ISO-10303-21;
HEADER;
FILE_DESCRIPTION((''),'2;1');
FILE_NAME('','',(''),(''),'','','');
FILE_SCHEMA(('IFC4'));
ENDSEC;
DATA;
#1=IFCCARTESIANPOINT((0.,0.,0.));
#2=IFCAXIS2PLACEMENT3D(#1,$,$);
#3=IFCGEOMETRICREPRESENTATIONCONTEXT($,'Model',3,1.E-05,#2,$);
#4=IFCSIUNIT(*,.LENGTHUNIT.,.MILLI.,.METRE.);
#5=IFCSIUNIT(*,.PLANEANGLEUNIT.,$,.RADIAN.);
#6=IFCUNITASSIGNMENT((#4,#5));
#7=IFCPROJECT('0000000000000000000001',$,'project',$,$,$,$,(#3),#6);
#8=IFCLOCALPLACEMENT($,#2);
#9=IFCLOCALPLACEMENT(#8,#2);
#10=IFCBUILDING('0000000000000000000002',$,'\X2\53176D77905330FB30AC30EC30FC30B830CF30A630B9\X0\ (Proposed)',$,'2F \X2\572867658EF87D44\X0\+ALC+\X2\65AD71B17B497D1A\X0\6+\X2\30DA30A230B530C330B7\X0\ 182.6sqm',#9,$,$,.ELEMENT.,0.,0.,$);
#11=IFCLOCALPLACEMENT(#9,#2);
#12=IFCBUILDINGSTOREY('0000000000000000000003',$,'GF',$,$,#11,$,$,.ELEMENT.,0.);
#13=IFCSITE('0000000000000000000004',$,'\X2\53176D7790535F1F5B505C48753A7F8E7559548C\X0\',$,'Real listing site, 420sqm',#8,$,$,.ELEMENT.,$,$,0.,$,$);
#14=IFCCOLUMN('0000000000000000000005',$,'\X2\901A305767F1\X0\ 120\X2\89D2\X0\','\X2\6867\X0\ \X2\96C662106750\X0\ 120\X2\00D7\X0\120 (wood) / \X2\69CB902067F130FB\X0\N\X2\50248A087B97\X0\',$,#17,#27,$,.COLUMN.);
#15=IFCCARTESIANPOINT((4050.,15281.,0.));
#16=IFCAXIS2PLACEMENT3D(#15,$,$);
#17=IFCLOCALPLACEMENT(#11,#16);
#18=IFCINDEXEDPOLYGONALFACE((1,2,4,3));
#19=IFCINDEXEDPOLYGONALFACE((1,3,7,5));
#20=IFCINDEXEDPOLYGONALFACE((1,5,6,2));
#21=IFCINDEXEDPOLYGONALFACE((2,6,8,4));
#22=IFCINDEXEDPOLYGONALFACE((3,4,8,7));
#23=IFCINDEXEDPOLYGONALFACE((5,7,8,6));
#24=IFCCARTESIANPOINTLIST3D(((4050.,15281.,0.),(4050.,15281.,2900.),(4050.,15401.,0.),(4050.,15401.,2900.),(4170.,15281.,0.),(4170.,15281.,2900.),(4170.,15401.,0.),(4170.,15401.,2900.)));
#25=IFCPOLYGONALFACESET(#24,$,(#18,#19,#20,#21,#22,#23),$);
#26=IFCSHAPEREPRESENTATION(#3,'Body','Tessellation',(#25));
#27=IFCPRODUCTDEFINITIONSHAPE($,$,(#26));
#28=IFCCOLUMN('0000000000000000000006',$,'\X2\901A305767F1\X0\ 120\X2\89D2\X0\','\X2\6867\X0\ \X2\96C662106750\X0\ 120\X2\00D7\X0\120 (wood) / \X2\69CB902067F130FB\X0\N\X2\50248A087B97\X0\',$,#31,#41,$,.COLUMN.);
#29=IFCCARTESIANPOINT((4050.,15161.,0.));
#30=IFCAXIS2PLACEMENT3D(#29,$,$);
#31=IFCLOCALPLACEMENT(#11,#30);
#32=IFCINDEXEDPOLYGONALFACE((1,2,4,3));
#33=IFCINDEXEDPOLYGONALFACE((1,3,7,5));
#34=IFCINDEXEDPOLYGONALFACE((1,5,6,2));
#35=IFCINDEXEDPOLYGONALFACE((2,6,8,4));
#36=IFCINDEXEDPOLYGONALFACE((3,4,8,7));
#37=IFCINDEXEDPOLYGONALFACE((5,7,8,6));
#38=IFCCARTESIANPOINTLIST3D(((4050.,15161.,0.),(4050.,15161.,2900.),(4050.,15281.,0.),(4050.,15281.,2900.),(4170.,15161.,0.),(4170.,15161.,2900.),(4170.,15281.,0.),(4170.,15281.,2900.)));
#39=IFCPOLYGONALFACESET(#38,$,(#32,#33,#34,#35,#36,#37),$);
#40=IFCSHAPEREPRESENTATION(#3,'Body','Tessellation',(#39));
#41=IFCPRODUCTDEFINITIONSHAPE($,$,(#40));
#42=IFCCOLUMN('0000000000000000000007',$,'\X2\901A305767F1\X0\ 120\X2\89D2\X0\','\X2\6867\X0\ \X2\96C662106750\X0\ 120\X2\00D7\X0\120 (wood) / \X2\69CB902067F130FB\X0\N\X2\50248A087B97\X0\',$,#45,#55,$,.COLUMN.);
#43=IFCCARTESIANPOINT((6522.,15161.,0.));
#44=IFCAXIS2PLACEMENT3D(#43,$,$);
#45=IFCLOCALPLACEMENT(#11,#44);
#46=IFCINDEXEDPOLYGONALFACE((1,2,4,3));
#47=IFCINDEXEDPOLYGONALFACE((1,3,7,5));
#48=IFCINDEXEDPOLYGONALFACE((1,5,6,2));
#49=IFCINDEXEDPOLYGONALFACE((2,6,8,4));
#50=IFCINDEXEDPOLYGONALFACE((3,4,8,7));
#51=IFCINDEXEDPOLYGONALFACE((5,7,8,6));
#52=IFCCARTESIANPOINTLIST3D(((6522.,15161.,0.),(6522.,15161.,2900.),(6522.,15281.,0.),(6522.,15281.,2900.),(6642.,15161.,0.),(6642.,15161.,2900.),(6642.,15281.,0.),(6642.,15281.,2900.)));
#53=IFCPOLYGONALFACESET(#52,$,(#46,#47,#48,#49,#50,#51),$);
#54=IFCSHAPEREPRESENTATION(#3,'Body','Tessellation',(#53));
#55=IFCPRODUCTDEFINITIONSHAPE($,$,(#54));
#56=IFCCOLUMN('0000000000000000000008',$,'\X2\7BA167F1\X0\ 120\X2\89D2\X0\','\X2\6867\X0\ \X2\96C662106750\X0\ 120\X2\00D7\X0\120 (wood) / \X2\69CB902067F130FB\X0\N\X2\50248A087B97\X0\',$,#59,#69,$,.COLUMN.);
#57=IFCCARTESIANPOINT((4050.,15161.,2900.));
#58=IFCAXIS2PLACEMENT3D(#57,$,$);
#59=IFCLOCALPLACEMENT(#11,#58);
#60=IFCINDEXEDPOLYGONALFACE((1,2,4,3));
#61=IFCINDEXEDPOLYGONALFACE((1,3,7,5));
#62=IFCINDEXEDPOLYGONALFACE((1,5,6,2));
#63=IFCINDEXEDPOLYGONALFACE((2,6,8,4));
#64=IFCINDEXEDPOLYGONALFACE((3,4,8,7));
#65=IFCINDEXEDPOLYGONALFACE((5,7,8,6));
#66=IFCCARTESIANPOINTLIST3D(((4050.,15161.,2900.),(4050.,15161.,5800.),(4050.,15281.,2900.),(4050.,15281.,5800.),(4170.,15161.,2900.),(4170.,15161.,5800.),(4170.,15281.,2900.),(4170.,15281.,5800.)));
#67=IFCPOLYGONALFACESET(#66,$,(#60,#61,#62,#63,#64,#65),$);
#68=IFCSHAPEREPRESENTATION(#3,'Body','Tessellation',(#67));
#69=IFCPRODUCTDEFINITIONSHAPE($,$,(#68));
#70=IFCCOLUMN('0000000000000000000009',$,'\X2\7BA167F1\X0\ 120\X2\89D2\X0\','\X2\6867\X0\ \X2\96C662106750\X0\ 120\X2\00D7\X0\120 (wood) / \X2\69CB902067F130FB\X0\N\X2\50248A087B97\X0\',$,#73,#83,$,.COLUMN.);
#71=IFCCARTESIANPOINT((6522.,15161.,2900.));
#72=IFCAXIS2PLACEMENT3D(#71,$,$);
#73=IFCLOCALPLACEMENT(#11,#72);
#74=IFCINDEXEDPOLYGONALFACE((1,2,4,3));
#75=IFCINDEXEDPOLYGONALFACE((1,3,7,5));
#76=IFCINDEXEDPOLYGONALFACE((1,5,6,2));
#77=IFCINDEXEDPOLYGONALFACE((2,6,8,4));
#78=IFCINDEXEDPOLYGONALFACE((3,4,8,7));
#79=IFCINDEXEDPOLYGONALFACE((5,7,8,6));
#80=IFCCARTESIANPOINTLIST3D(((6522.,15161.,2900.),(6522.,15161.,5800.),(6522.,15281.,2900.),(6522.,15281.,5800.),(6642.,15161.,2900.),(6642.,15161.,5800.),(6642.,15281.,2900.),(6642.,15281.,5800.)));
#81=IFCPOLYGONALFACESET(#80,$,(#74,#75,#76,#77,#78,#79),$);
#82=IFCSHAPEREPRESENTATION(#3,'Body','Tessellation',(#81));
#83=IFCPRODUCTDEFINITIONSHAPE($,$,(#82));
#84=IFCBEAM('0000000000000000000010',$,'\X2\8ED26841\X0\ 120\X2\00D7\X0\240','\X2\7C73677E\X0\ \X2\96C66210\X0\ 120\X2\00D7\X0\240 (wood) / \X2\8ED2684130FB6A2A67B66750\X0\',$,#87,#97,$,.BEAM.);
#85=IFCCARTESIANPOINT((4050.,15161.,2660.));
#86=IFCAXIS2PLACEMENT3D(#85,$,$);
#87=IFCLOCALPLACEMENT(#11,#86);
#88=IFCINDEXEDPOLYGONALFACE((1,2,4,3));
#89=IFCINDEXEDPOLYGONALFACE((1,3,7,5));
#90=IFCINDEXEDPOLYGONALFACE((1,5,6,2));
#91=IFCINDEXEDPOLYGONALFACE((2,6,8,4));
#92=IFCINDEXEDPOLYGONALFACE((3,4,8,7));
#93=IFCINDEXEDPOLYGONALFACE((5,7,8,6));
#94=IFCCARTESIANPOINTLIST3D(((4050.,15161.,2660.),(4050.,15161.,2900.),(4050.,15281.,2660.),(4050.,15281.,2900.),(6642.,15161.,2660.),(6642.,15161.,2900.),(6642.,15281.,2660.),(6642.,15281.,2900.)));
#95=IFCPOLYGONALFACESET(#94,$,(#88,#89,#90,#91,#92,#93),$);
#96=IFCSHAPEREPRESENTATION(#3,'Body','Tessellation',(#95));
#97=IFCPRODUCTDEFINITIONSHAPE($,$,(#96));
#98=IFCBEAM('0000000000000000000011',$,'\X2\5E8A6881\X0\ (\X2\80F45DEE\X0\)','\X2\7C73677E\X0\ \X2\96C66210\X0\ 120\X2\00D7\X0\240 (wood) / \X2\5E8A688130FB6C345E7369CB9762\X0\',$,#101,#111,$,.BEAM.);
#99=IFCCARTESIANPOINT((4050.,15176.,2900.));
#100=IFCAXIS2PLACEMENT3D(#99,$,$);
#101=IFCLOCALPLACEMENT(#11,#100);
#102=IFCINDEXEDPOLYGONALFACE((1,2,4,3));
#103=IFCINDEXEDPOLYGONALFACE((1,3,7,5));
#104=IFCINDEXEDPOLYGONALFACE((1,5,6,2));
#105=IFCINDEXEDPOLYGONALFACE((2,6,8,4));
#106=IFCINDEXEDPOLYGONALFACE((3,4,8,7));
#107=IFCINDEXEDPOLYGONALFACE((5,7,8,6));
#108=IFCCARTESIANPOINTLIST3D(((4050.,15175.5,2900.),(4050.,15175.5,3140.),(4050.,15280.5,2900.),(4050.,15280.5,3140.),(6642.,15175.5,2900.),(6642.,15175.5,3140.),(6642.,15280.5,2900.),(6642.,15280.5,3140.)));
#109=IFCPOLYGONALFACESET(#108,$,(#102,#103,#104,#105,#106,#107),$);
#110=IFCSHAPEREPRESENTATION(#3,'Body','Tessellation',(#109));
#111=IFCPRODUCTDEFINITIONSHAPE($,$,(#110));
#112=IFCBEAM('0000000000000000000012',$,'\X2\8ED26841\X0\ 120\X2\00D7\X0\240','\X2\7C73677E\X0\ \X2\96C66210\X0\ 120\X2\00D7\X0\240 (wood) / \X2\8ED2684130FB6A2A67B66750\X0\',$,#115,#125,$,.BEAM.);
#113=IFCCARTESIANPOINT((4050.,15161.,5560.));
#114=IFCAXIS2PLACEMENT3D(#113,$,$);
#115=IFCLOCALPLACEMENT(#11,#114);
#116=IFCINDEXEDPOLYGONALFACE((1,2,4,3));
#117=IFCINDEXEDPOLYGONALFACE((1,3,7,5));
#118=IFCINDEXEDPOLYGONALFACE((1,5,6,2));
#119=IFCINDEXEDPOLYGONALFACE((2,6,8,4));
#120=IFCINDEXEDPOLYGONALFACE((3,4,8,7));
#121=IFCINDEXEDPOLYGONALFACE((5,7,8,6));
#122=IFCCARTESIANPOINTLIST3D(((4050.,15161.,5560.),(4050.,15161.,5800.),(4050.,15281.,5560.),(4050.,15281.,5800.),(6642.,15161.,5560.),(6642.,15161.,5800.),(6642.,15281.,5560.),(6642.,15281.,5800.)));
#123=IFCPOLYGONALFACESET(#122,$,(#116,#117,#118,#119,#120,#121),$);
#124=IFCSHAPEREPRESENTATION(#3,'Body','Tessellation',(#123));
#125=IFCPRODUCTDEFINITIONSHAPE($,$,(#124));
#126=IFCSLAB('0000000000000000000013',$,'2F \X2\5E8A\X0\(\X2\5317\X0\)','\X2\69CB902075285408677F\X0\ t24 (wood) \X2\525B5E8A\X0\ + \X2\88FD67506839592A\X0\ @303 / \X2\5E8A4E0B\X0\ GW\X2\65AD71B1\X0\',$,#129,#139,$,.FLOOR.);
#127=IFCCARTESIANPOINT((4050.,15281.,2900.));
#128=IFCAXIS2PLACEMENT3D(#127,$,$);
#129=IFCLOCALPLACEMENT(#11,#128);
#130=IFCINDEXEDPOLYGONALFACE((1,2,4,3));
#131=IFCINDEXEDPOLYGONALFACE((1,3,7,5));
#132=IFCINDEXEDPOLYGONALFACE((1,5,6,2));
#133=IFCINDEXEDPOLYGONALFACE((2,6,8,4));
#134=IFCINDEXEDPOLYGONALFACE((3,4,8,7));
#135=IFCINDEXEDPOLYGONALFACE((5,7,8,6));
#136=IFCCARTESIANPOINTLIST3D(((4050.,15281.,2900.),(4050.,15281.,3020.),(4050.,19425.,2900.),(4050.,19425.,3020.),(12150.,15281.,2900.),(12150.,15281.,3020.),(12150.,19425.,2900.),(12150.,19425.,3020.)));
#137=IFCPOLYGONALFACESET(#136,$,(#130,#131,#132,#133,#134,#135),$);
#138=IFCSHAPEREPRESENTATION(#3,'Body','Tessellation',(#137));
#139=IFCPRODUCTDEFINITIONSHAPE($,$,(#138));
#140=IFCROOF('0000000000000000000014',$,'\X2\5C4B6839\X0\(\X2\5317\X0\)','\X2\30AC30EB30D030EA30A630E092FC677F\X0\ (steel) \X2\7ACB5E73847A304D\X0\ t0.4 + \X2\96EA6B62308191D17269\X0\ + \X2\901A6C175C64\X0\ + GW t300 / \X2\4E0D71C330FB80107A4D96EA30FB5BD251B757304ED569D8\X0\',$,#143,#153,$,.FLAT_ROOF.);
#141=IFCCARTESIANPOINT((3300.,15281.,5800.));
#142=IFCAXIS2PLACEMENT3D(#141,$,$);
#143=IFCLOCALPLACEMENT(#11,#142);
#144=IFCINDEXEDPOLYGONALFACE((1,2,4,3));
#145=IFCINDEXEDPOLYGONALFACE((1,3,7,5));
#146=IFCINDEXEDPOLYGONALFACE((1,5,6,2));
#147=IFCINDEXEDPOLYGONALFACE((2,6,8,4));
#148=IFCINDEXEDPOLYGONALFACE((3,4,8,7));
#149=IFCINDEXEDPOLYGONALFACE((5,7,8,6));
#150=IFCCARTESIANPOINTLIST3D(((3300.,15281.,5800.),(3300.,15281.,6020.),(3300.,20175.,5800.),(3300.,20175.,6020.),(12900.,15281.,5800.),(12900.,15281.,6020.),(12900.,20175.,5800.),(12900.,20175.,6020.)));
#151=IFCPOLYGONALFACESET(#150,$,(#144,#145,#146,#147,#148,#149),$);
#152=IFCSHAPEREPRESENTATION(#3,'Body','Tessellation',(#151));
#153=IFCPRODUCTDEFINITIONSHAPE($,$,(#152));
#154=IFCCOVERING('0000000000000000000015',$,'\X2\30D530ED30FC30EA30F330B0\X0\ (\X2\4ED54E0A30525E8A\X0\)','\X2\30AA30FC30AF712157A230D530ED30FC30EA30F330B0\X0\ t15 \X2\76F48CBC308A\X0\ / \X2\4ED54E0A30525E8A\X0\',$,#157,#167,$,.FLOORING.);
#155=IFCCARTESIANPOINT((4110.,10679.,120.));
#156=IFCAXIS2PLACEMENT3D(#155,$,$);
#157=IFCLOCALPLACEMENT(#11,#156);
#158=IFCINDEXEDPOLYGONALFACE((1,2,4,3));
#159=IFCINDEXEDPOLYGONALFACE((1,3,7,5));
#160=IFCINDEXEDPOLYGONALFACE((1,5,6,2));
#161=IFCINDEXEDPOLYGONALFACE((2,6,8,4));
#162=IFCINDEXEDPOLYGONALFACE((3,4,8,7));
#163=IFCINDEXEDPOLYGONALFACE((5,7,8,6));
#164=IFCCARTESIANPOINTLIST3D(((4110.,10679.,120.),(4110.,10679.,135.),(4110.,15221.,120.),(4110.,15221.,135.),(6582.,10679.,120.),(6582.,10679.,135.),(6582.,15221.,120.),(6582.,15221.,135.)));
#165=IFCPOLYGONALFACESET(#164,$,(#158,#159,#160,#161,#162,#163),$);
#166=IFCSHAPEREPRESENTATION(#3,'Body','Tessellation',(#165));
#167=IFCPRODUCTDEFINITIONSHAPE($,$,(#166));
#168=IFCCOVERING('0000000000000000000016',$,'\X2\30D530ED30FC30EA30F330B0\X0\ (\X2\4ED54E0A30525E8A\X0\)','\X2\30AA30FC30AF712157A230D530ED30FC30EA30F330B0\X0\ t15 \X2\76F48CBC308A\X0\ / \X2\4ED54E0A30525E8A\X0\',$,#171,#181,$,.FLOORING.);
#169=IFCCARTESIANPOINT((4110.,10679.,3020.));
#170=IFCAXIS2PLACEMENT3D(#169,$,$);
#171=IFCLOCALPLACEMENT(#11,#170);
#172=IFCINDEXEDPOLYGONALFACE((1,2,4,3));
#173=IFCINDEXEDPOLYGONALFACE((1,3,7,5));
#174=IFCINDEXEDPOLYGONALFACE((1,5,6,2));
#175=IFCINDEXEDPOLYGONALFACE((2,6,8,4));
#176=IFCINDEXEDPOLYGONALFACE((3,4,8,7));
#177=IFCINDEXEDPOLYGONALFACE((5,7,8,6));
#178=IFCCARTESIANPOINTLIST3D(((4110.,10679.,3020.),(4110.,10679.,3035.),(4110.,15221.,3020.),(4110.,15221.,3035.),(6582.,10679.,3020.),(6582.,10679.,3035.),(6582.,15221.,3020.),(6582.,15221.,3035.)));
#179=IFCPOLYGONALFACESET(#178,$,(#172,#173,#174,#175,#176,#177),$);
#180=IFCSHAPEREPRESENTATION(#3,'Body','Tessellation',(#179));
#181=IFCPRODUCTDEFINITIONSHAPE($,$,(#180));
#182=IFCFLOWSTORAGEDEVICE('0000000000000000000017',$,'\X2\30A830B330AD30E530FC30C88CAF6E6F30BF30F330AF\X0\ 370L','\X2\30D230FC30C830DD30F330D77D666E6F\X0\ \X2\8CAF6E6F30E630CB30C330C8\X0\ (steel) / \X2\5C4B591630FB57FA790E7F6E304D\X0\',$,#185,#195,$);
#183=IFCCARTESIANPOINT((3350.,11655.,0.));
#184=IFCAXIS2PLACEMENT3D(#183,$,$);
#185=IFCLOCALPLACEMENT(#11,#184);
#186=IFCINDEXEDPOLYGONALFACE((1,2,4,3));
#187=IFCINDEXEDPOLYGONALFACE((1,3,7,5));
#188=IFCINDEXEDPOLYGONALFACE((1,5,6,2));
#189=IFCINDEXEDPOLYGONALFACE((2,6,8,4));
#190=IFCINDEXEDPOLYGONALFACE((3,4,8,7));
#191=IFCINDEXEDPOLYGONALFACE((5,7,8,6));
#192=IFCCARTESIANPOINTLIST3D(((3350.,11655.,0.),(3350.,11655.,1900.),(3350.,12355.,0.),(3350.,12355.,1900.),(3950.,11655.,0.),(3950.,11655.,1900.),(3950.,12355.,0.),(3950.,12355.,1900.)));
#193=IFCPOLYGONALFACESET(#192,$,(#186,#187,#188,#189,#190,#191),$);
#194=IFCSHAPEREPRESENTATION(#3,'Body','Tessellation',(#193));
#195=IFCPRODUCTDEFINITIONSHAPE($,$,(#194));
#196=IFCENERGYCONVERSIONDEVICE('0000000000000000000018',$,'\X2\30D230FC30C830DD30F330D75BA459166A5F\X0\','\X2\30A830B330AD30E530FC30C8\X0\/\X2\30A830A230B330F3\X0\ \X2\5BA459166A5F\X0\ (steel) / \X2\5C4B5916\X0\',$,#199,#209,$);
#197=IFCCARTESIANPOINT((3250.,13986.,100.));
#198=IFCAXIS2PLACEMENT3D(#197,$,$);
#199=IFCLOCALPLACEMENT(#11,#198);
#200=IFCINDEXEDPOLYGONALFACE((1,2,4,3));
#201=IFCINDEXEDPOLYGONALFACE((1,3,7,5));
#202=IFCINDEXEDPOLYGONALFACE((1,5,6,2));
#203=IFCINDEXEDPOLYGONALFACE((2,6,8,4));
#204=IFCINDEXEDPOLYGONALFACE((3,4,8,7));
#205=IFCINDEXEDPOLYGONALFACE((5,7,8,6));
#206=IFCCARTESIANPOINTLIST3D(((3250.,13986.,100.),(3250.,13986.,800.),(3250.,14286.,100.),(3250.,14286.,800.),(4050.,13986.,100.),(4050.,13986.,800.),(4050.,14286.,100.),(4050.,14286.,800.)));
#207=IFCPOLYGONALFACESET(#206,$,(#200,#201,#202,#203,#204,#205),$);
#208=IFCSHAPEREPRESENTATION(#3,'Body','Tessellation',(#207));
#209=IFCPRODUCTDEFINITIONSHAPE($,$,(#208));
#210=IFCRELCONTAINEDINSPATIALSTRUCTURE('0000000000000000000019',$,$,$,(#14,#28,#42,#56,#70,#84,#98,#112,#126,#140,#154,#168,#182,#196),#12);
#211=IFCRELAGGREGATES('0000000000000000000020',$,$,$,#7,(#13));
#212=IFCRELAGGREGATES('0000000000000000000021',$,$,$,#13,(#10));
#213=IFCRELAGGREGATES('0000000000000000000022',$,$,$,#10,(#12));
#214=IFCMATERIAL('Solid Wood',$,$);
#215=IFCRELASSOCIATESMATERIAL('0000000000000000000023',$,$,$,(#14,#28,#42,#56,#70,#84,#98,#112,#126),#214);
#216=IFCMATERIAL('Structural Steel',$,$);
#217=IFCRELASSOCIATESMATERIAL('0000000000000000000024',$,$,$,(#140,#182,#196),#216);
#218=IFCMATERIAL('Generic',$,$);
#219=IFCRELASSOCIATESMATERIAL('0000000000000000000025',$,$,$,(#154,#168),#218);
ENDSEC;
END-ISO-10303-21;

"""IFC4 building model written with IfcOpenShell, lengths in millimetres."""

from ifc_helpers import new_model, si_unit, frame, frame_2d, origin, place, context, project, spatial, rectangle, extrude, material, element, save


model = new_model("IFC4")

# Units and contexts
model_context = context("Model", 3, precision=1e-05, world=origin())
ifc_project = project(units=[si_unit("LENGTHUNIT", "METRE", prefix="MILLI"), si_unit("PLANEANGLEUNIT", "RADIAN")], contexts=[model_context])

# Site, building, storey
site_placement = place(None, origin())
site = spatial("IfcSite", under=ifc_project, at=site_placement, Name="北海道弟子屈町美留和", ObjectType="Real listing site, 420sqm", CompositionType="ELEMENT", RefElevation=0.0)
building_placement = place(site_placement, origin())
building = spatial("IfcBuilding", under=site, at=building_placement, Name="北海道・ガレージハウス (Proposed)", ObjectType="2F 在来軸組+ALC+断熱等級6+ペアサッシ 182.6sqm", CompositionType="ELEMENT", ElevationOfRefHeight=0.0, ElevationOfTerrain=0.0)
storey_placement = place(building_placement, origin())
storey = spatial("IfcBuildingStorey", under=building, at=storey_placement, Name="GF", CompositionType="ELEMENT", Elevation=0.0)

# Columns
ifc_material_1 = material(Name="Solid Wood")
column_1_placement = place(storey_placement, frame((4050.0, 15281.0, 0.0)))
element("IfcColumn", 1, at=column_1_placement, inside=storey, material=ifc_material_1, Name="通し柱 120角", Description="桧 集成材 120×120 (wood) / 構造柱・N値計算", PredefinedType="COLUMN", context=model_context, shape_type="SweptSolid", body=[
    extrude(rectangle(XDim=120.0, YDim=120.0, at=frame_2d((60.0, 60.0))), frame((4050.0, 15281.0, 0.0)), (0.0, 0.0, 1.0), 2900.0),
])
column_2_placement = place(storey_placement, frame((4050.0, 15161.0, 0.0)))
element("IfcColumn", 2, at=column_2_placement, inside=storey, material=ifc_material_1, Name="通し柱 120角", Description="桧 集成材 120×120 (wood) / 構造柱・N値計算", PredefinedType="COLUMN", context=model_context, shape_type="SweptSolid", body=[
    extrude(rectangle(XDim=120.0, YDim=120.0, at=frame_2d((60.0, 60.0))), frame((4050.0, 15161.0, 0.0)), (0.0, 0.0, 1.0), 2900.0),
])
column_3_placement = place(storey_placement, frame((6522.0, 15161.0, 0.0)))
element("IfcColumn", 3, at=column_3_placement, inside=storey, material=ifc_material_1, Name="通し柱 120角", Description="桧 集成材 120×120 (wood) / 構造柱・N値計算", PredefinedType="COLUMN", context=model_context, shape_type="SweptSolid", body=[
    extrude(rectangle(XDim=120.0, YDim=120.0, at=frame_2d((60.0, 60.0))), frame((6522.0, 15161.0, 0.0)), (0.0, 0.0, 1.0), 2900.0),
])
column_4_placement = place(storey_placement, frame((4050.0, 15161.0, 2900.0)))
element("IfcColumn", 4, at=column_4_placement, inside=storey, material=ifc_material_1, Name="管柱 120角", Description="桧 集成材 120×120 (wood) / 構造柱・N値計算", PredefinedType="COLUMN", context=model_context, shape_type="SweptSolid", body=[
    extrude(rectangle(XDim=120.0, YDim=120.0, at=frame_2d((60.0, 60.0))), frame((4050.0, 15161.0, 2900.0)), (0.0, 0.0, 1.0), 2900.0),
])
column_5_placement = place(storey_placement, frame((6522.0, 15161.0, 2900.0)))
element("IfcColumn", 5, at=column_5_placement, inside=storey, material=ifc_material_1, Name="管柱 120角", Description="桧 集成材 120×120 (wood) / 構造柱・N値計算", PredefinedType="COLUMN", context=model_context, shape_type="SweptSolid", body=[
    extrude(rectangle(XDim=120.0, YDim=120.0, at=frame_2d((60.0, 60.0))), frame((6522.0, 15161.0, 2900.0)), (0.0, 0.0, 1.0), 2900.0),
])

# Beams
beam_1_placement = place(storey_placement, frame((4050.0, 15161.0, 2660.0)))
element("IfcBeam", 6, at=beam_1_placement, inside=storey, material=ifc_material_1, Name="軒桁 120×240", Description="米松 集成 120×240 (wood) / 軒桁・横架材", PredefinedType="BEAM", context=model_context, shape_type="SweptSolid", body=[
    extrude(rectangle(XDim=2592.0, YDim=120.0, at=frame_2d((1296.0, 60.0))), frame((4050.0, 15161.0, 2660.0)), (0.0, 0.0, 1.0), 240.0),
])
beam_2_placement = place(storey_placement, frame((4050.0, 15176.0, 2900.0)))
element("IfcBeam", 7, at=beam_2_placement, inside=storey, material=ifc_material_1, Name="床梁 (胴差)", Description="米松 集成 120×240 (wood) / 床梁・水平構面", PredefinedType="BEAM", context=model_context, shape_type="SweptSolid", body=[
    extrude(rectangle(XDim=2592.0, YDim=105.0, at=frame_2d((1296.0, 52.0))), frame((4050.0, 15176.0, 2900.0)), (0.0, 0.0, 1.0), 240.0),
])
beam_3_placement = place(storey_placement, frame((4050.0, 15161.0, 5560.0)))
element("IfcBeam", 8, at=beam_3_placement, inside=storey, material=ifc_material_1, Name="軒桁 120×240", Description="米松 集成 120×240 (wood) / 軒桁・横架材", PredefinedType="BEAM", context=model_context, shape_type="SweptSolid", body=[
    extrude(rectangle(XDim=2592.0, YDim=120.0, at=frame_2d((1296.0, 60.0))), frame((4050.0, 15161.0, 5560.0)), (0.0, 0.0, 1.0), 240.0),
])

# Slab
slab_1_placement = place(storey_placement, frame((4050.0, 15281.0, 2900.0)))
element("IfcSlab", 9, at=slab_1_placement, inside=storey, material=ifc_material_1, Name="2F 床(北)", Description="構造用合板 t24 (wood) 剛床 + 製材根太 @303 / 床下 GW断熱", PredefinedType="FLOOR", context=model_context, shape_type="SweptSolid", body=[
    extrude(rectangle(XDim=8100.0, YDim=4144.0, at=frame_2d((4050.0, 2072.0))), frame((4050.0, 15281.0, 2900.0)), (0.0, 0.0, 1.0), 120.0),
])

# Roof
ifc_material_2 = material(Name="Structural Steel")
for number, where, name in (
    (10, (3300.0, 15281.0, 5800.0), "屋根(北)"),
):
    element("IfcRoof", number, at=place(storey_placement, frame(where)), inside=storey, material=ifc_material_2, Name=name, Description="ガルバリウム鋼板 (steel) 立平葺き t0.4 + 雪止め金物 + 通気層 + GW t300 / 不燃・耐積雪・寒冷地仕様", PredefinedType="FLAT_ROOF", context=model_context, shape_type="SweptSolid", body=[
        extrude(rectangle(XDim=9600.0, YDim=4894.0, at=frame_2d((4800.0, 2447.0))), frame((3300.0, 15281.0, 5800.0)), (0.0, 0.0, 1.0), 220.0),
    ])

# Coverings
ifc_material_3 = material(Name="Generic")
covering_1_placement = place(storey_placement, frame((4110.0, 10679.0, 120.0)))
element("IfcCovering", 11, at=covering_1_placement, inside=storey, material=ifc_material_3, Name="フローリング (仕上げ床)", Description="オーク無垢フローリング t15 直貼り / 仕上げ床", PredefinedType="FLOORING", context=model_context, shape_type="SweptSolid", body=[
    extrude(rectangle(XDim=2472.0, YDim=4542.0, at=frame_2d((1236.0, 2271.0))), frame((4110.0, 10679.0, 120.0)), (0.0, 0.0, 1.0), 15.0),
])
covering_2_placement = place(storey_placement, frame((4110.0, 10679.0, 3020.0)))
element("IfcCovering", 12, at=covering_2_placement, inside=storey, material=ifc_material_3, Name="フローリング (仕上げ床)", Description="オーク無垢フローリング t15 直貼り / 仕上げ床", PredefinedType="FLOORING", context=model_context, shape_type="SweptSolid", body=[
    extrude(rectangle(XDim=2472.0, YDim=4542.0, at=frame_2d((1236.0, 2271.0))), frame((4110.0, 10679.0, 3020.0)), (0.0, 0.0, 1.0), 15.0),
])

# Flow storage device
flow_storage_device_placement = place(storey_placement, frame((3350.0, 11655.0, 0.0)))
element("IfcFlowStorageDevice", 13, at=flow_storage_device_placement, inside=storey, material=ifc_material_2, Name="エコキュート貯湯タンク 370L", Description="ヒートポンプ給湯 貯湯ユニット (steel) / 屋外・基礎置き", context=model_context, shape_type="SweptSolid", body=[
    extrude(rectangle(XDim=600.0, YDim=700.0, at=frame_2d((300.0, 350.0))), frame((3350.0, 11655.0, 0.0)), (0.0, 0.0, 1.0), 1900.0),
])

# Energy conversion device
energy_conversion_device_placement = place(storey_placement, frame((3250.0, 13986.0, 100.0)))
element("IfcEnergyConversionDevice", 14, at=energy_conversion_device_placement, inside=storey, material=ifc_material_2, Name="ヒートポンプ室外機", Description="エコキュート/エアコン 室外機 (steel) / 屋外", context=model_context, shape_type="SweptSolid", body=[
    extrude(rectangle(XDim=800.0, YDim=300.0, at=frame_2d((400.0, 150.0))), frame((3250.0, 13986.0, 100.0)), (0.0, 0.0, 1.0), 700.0),
])

save(model, "model.ifc")
